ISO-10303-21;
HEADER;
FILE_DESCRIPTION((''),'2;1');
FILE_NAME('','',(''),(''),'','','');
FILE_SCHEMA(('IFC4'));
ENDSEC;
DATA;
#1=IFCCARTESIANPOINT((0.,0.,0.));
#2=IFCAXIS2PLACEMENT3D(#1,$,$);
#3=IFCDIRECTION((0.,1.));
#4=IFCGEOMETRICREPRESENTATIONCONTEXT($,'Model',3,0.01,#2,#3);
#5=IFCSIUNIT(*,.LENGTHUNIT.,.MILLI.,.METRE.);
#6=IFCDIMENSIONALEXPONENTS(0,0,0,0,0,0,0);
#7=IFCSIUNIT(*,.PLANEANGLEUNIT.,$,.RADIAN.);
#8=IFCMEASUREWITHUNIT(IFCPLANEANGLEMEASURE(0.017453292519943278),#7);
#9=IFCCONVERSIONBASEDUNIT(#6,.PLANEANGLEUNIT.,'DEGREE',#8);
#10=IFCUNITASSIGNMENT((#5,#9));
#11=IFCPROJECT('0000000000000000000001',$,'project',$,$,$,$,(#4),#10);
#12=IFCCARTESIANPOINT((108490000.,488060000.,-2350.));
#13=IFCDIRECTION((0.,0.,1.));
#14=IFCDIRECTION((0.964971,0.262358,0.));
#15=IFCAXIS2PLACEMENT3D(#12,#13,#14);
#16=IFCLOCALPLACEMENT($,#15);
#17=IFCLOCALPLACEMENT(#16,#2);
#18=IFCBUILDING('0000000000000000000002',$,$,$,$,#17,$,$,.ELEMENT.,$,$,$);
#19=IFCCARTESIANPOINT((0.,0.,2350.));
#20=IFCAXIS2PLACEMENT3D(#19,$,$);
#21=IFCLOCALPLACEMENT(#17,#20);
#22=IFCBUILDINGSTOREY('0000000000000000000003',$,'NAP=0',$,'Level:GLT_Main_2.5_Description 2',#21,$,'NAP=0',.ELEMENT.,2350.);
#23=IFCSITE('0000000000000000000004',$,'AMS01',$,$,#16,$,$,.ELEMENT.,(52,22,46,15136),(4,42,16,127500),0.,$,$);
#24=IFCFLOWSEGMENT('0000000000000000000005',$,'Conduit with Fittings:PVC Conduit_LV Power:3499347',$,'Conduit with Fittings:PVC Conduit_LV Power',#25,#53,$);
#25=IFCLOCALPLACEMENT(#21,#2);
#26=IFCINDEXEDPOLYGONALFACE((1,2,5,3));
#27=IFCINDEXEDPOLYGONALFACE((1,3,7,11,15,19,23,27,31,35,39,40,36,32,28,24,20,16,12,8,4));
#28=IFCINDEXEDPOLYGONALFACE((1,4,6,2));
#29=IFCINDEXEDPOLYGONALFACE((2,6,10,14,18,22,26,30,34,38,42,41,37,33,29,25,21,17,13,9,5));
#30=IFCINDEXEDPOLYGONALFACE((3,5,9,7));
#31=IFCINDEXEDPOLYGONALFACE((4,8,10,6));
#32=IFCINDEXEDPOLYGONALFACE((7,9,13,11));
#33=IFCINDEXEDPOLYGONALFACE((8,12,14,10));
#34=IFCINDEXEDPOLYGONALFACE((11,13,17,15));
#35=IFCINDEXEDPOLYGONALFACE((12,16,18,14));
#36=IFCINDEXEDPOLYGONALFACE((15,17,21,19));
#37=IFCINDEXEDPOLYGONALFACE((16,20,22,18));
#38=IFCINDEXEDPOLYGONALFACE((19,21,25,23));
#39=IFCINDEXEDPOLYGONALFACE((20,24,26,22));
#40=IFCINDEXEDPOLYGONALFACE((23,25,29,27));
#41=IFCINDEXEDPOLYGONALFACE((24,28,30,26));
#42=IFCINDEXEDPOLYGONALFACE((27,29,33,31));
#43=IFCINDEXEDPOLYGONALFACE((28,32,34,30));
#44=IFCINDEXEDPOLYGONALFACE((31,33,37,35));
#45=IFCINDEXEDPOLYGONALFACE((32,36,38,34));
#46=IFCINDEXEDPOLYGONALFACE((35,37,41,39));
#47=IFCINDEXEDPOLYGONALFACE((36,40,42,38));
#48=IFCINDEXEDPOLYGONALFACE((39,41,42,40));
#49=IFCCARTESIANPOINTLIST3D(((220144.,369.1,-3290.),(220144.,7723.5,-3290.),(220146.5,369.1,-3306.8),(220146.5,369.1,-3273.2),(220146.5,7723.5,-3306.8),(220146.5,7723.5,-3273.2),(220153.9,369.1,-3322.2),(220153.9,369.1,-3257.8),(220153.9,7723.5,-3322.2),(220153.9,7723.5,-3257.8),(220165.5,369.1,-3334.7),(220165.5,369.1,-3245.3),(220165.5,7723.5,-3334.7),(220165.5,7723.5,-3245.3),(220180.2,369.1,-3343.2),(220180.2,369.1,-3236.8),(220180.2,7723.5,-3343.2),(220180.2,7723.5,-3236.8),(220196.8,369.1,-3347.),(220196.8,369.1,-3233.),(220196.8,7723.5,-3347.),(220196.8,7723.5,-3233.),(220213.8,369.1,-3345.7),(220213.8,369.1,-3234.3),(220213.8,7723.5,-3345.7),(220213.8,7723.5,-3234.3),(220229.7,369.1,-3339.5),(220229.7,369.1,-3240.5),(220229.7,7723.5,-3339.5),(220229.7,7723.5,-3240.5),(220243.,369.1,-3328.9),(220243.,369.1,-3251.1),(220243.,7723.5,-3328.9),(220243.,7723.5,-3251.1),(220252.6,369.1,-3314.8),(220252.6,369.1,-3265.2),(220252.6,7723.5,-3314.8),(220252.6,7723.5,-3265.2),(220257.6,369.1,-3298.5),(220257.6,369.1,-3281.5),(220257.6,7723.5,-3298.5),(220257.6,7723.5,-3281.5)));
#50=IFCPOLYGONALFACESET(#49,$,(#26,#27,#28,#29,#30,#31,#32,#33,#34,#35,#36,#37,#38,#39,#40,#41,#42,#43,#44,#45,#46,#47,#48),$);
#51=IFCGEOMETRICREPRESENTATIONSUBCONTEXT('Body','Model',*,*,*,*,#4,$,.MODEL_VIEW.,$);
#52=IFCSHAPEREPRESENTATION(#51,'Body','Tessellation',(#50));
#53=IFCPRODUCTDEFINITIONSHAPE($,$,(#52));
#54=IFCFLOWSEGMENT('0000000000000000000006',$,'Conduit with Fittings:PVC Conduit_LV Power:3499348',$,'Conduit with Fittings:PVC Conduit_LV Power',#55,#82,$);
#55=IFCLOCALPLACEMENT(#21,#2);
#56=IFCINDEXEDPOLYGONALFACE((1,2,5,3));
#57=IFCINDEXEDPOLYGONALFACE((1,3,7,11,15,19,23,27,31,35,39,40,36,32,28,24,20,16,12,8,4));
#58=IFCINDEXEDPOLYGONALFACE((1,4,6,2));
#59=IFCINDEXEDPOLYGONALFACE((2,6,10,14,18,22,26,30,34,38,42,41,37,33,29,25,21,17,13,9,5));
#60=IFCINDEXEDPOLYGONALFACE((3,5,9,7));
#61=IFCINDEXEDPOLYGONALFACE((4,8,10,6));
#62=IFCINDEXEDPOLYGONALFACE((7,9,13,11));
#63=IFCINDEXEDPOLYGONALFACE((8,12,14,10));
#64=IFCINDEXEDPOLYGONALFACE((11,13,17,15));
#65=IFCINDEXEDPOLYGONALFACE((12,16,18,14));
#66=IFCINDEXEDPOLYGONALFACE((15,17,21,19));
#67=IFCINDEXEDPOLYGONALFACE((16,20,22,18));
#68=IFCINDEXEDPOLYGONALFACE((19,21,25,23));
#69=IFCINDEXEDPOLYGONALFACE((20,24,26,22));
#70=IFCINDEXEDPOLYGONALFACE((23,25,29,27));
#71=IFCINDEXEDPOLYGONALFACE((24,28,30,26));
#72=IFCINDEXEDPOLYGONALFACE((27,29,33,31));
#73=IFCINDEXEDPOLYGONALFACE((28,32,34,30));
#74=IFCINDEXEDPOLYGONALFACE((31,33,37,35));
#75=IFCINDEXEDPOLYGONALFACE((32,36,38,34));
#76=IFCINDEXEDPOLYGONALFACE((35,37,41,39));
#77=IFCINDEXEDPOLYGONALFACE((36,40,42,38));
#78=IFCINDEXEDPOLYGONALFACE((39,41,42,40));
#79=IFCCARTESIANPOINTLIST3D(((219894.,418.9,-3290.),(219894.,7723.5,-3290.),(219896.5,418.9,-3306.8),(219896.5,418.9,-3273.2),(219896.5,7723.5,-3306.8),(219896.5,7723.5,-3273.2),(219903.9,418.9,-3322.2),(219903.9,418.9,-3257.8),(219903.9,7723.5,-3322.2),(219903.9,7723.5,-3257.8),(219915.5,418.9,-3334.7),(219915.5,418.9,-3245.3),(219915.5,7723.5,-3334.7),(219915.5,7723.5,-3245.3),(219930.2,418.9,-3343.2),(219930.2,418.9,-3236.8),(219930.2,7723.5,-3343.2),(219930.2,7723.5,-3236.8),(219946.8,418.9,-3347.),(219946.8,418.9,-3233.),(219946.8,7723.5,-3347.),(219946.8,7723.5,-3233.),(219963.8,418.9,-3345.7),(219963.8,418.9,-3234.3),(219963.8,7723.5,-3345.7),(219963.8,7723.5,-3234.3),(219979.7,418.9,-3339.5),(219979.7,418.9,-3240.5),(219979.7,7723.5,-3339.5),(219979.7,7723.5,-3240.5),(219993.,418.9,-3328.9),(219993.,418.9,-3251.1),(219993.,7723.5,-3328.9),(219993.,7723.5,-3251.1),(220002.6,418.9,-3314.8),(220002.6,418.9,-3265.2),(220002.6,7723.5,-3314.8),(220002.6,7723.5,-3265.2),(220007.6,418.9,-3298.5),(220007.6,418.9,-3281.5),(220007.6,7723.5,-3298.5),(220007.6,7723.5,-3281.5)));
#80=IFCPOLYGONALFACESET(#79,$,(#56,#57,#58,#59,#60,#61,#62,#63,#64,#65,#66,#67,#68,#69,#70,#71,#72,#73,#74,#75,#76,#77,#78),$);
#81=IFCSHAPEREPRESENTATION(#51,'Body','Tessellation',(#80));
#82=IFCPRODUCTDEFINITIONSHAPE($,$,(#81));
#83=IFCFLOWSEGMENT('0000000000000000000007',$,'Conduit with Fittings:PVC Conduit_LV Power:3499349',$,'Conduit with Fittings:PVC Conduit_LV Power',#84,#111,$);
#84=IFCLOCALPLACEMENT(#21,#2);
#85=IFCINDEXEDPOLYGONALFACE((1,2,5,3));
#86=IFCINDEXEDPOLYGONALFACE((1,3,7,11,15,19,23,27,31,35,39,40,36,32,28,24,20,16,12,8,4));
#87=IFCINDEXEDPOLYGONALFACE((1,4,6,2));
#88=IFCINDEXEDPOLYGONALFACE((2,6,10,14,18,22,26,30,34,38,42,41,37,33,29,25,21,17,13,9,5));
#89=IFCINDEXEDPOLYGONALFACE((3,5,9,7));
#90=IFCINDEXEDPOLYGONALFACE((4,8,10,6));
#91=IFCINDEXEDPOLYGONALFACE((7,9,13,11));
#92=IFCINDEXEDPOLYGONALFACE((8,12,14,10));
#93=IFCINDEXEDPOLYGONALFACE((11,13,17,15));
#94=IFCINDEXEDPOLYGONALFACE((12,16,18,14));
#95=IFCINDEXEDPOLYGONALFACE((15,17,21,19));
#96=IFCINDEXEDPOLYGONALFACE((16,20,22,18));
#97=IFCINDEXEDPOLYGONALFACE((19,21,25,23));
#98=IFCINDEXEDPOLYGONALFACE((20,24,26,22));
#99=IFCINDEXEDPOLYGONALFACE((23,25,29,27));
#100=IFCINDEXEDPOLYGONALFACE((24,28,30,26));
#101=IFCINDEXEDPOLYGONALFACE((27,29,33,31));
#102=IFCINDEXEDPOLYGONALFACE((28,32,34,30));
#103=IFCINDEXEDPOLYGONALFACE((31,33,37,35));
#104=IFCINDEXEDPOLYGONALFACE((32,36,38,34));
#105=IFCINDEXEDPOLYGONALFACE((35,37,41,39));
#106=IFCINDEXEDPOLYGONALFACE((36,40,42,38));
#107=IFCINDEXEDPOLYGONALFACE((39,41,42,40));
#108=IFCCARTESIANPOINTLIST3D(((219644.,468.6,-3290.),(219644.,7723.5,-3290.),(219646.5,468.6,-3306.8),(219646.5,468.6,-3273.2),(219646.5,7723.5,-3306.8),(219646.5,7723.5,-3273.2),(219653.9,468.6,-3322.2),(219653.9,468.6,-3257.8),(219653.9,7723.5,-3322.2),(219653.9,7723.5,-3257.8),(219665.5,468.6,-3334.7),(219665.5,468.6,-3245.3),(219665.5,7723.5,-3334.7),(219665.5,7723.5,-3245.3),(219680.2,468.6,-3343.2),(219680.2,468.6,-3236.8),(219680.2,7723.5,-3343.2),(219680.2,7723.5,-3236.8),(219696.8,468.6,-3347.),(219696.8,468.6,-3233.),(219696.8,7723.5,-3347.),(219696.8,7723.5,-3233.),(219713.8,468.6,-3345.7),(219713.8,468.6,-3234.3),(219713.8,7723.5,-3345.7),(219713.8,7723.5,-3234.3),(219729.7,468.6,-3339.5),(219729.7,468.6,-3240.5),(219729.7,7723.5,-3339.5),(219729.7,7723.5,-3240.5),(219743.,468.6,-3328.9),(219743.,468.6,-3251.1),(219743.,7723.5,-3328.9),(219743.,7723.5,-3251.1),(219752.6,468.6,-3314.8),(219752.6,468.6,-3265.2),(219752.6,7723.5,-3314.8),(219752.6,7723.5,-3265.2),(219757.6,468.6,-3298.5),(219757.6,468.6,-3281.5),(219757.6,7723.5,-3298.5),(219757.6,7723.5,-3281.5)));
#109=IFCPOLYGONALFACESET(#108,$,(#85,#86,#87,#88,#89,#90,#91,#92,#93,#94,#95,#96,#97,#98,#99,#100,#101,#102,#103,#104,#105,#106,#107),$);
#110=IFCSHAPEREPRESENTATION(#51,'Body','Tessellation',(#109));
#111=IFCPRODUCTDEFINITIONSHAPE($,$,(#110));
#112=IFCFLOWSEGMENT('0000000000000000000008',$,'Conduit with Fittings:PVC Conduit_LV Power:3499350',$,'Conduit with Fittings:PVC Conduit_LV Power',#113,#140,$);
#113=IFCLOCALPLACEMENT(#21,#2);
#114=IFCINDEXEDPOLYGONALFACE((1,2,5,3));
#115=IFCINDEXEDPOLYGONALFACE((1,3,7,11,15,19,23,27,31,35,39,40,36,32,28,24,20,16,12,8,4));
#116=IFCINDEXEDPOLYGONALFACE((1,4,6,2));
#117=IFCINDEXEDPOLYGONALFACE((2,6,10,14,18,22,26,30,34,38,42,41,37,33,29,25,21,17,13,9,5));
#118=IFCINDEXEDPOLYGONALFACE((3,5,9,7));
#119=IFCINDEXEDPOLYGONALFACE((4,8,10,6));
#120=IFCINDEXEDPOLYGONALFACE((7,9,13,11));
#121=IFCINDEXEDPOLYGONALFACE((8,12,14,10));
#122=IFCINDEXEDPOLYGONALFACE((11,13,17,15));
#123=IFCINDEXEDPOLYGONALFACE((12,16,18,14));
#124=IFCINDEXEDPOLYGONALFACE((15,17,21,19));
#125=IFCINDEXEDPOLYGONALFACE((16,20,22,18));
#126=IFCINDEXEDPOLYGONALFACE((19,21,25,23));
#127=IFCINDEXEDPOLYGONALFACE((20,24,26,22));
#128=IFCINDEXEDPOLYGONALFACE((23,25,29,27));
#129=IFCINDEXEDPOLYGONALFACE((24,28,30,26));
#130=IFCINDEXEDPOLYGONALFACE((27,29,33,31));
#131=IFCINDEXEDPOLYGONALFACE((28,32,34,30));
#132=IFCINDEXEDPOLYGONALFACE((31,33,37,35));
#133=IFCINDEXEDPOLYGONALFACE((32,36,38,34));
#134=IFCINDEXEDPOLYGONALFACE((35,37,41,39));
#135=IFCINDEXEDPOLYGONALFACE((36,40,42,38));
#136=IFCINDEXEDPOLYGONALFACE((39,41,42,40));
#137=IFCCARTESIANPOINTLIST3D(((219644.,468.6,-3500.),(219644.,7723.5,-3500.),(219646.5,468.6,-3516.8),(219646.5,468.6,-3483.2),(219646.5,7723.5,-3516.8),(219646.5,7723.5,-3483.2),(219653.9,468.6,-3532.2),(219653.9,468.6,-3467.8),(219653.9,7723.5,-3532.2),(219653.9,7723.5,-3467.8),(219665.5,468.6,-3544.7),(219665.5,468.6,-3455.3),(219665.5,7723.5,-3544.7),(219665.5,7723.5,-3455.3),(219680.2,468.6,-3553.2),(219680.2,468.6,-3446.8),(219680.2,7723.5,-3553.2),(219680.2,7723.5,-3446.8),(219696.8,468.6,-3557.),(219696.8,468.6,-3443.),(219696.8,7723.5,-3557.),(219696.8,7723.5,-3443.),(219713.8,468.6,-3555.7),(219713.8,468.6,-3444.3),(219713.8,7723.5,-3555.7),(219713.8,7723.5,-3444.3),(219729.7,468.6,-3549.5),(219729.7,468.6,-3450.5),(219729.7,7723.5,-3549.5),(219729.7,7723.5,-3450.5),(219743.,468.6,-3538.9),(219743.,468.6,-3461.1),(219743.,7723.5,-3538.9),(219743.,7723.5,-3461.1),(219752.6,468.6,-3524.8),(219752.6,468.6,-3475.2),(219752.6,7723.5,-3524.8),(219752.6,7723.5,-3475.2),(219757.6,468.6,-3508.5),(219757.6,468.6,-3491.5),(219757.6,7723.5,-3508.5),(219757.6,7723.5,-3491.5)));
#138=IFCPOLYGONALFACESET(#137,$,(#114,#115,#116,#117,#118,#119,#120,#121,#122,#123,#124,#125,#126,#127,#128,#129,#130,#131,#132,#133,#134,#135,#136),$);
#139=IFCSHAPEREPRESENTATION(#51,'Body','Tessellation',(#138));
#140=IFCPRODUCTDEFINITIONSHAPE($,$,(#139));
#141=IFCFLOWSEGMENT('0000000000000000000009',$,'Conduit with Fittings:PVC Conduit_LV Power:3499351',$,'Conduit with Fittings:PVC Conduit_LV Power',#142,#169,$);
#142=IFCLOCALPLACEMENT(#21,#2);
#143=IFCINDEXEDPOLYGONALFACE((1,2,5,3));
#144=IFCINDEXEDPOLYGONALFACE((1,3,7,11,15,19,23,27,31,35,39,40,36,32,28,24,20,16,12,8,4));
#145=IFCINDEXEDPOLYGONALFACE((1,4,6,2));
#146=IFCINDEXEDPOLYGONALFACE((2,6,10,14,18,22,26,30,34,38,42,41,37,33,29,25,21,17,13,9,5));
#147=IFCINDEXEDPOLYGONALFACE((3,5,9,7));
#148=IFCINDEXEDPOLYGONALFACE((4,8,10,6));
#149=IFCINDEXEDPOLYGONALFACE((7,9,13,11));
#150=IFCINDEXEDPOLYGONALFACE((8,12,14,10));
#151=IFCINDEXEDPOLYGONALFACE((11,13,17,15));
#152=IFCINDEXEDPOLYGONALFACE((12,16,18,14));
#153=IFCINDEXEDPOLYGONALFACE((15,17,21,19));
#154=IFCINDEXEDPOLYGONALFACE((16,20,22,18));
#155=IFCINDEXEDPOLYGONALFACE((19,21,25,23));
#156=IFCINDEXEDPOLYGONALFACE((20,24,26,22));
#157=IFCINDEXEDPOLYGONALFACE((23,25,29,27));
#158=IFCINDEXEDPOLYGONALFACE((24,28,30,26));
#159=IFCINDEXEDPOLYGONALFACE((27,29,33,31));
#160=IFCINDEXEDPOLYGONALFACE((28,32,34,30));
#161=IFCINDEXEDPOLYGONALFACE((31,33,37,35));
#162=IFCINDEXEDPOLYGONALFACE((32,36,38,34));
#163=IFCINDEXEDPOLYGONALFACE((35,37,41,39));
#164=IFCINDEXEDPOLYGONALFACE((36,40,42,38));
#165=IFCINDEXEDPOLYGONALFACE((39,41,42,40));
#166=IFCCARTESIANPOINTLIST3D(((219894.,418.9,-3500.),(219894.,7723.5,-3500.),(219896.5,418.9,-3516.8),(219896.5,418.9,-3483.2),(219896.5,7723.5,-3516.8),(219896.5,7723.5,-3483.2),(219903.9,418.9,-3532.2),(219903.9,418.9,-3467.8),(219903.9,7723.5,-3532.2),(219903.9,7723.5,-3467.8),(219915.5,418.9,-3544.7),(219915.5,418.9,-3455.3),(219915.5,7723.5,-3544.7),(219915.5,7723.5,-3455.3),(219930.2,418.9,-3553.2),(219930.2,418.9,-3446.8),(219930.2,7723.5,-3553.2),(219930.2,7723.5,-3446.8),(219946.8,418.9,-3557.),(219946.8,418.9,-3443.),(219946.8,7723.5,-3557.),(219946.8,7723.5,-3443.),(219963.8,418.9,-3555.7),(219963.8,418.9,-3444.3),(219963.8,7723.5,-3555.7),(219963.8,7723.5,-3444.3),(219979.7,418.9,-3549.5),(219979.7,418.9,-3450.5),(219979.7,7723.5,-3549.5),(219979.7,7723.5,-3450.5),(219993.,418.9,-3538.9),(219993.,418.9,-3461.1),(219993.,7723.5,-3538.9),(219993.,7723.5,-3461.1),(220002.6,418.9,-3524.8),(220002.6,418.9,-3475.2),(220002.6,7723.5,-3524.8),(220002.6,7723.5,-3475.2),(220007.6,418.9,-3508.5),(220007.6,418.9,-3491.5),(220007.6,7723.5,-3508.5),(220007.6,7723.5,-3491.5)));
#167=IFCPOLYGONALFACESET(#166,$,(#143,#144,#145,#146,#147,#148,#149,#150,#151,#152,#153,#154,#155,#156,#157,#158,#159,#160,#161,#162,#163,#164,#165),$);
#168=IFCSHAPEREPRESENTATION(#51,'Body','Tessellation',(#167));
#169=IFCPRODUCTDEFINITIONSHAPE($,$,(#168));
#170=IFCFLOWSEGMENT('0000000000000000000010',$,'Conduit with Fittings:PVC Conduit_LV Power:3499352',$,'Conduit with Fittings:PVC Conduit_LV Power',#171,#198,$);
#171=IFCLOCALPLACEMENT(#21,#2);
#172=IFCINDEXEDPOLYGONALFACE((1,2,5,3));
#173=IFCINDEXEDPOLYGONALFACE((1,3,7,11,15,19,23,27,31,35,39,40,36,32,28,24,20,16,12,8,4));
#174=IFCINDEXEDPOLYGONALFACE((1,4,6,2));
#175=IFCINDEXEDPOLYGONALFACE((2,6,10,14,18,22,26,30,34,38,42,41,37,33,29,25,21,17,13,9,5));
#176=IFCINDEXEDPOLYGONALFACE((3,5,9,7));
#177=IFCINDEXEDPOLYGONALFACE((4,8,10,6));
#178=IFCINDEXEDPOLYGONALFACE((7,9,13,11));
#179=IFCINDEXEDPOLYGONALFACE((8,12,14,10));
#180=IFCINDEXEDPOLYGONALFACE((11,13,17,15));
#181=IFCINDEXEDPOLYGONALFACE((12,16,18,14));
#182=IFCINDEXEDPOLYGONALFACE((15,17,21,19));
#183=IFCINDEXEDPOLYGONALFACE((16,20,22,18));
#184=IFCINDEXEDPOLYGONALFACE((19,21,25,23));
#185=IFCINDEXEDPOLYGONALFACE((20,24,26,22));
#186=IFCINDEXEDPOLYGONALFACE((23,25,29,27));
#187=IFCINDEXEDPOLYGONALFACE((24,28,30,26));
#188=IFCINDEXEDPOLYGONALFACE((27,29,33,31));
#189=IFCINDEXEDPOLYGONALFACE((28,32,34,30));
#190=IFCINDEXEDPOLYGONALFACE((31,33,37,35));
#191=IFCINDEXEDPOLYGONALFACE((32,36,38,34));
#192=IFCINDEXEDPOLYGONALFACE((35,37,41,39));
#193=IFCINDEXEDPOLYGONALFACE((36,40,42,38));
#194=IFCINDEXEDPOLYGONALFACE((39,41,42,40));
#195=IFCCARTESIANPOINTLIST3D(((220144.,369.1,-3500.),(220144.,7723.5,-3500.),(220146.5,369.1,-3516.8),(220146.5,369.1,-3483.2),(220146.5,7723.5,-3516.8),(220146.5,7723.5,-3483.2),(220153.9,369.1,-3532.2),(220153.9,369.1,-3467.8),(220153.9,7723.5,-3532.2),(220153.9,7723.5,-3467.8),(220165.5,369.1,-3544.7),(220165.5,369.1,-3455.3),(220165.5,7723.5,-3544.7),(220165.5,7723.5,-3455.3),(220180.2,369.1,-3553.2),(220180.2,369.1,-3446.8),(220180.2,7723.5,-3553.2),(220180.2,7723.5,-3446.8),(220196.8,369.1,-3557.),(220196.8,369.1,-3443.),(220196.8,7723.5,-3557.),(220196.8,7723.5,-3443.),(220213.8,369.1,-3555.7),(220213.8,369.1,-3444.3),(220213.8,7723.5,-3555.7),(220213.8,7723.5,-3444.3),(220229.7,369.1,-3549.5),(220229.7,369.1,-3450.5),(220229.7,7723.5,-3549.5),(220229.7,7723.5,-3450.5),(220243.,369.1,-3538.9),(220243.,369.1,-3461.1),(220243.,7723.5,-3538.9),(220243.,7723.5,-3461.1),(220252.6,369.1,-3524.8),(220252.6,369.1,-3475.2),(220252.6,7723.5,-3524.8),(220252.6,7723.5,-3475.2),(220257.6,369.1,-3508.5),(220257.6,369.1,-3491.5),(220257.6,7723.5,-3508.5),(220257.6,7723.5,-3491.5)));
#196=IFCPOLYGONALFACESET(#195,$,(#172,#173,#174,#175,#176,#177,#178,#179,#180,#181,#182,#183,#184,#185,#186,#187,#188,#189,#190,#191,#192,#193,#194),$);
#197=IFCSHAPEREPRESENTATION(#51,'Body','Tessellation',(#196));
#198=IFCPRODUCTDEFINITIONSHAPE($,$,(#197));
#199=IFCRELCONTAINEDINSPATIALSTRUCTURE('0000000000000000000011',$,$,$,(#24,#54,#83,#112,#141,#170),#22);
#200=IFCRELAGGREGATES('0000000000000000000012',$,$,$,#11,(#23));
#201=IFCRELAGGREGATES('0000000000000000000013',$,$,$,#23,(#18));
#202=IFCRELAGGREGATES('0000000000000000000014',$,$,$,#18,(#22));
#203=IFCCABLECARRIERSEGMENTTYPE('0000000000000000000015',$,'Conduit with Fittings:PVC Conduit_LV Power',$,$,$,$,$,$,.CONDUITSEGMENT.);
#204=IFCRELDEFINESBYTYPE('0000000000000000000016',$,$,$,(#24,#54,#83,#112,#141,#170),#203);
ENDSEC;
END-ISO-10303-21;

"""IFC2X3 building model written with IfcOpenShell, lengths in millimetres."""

from ifc_helpers import new_model, entity, si_unit, converted_unit, direction, frame, frame_2d, origin, place, context, subcontext, project, spatial, circle, extrude, type_object, element, save


model = new_model("IFC2X3")

# Units and contexts
model_context = context("Model", 3, precision=0.01, world=origin(), true_north=direction((0.0, 1.0)))
body_context = subcontext(model_context, "Body", "Model", "MODEL_VIEW")
ifc_project = project(units=[si_unit("LENGTHUNIT", "METRE", prefix="MILLI"), converted_unit("PLANEANGLEUNIT", "DEGREE", entity("IfcPlaneAngleMeasure", 0.017453292519943278), si_unit("PLANEANGLEUNIT", "RADIAN"), dimensions=[0, 0, 0, 0, 0, 0, 0])], contexts=[model_context])

# Site, building, storey
site_placement = place(None, frame((108490000.0, 488060000.0, -2350.0), z_axis=(0.0, 0.0, 1.0), x_axis=(0.964971, 0.262358, 0.0)))
site = spatial("IfcSite", under=ifc_project, at=site_placement, Name="AMS01", CompositionType="ELEMENT", RefLatitude=(52, 22, 46, 15136), RefLongitude=(4, 42, 16, 127500), RefElevation=0.0)
building_placement = place(site_placement, origin())
building = spatial("IfcBuilding", under=site, at=building_placement, CompositionType="ELEMENT")
storey_placement = place(building_placement, frame((0.0, 0.0, 2350.0)))
storey = spatial("IfcBuildingStorey", under=building, at=storey_placement, Name="NAP=0", ObjectType="Level:GLT_Main_2.5_Description 2", LongName="NAP=0", CompositionType="ELEMENT", Elevation=2350.0)

# Flow segments
cable_carrier_segment_type = type_object("IfcCableCarrierSegmentType", Name="Conduit with Fittings:PVC Conduit_LV Power", PredefinedType="CONDUITSEGMENT")
flow_segment_1_placement = place(storey_placement, origin())
element("IfcFlowSegment", 1, at=flow_segment_1_placement, inside=storey, type_object=cable_carrier_segment_type, Name="Conduit with Fittings:PVC Conduit_LV Power:3499347", ObjectType="Conduit with Fittings:PVC Conduit_LV Power", context=body_context, shape_type="SweptSolid", body=[
    extrude(circle(Radius=57.2, at=frame_2d((0.0, 0.0), x_axis=(1.0, 0.0))), frame((220201.1, 369.1, -3290.0), z_axis=(0.0, 1.0, 0.0), x_axis=(-1.0, 0.0, 0.0)), (0.0, 0.0, 1.0), 7354.3),
])
flow_segment_2_placement = place(storey_placement, origin())
element("IfcFlowSegment", 2, at=flow_segment_2_placement, inside=storey, type_object=cable_carrier_segment_type, Name="Conduit with Fittings:PVC Conduit_LV Power:3499348", ObjectType="Conduit with Fittings:PVC Conduit_LV Power", context=body_context, shape_type="SweptSolid", body=[
    extrude(circle(Radius=57.2, at=frame_2d((0.0, 0.0), x_axis=(1.0, 0.0))), frame((219951.1, 418.9, -3290.0), z_axis=(0.0, 1.0, 0.0), x_axis=(-1.0, 0.0, 0.0)), (0.0, 0.0, 1.0), 7304.6),
])
flow_segment_3_placement = place(storey_placement, origin())
element("IfcFlowSegment", 3, at=flow_segment_3_placement, inside=storey, type_object=cable_carrier_segment_type, Name="Conduit with Fittings:PVC Conduit_LV Power:3499349", ObjectType="Conduit with Fittings:PVC Conduit_LV Power", context=body_context, shape_type="SweptSolid", body=[
    extrude(circle(Radius=57.2, at=frame_2d((0.0, 0.0), x_axis=(1.0, 0.0))), frame((219701.1, 468.6, -3290.0), z_axis=(0.0, 1.0, 0.0), x_axis=(-1.0, 0.0, 0.0)), (0.0, 0.0, 1.0), 7254.9),
])
flow_segment_4_placement = place(storey_placement, origin())
element("IfcFlowSegment", 4, at=flow_segment_4_placement, inside=storey, type_object=cable_carrier_segment_type, Name="Conduit with Fittings:PVC Conduit_LV Power:3499350", ObjectType="Conduit with Fittings:PVC Conduit_LV Power", context=body_context, shape_type="SweptSolid", body=[
    extrude(circle(Radius=57.2, at=frame_2d((0.0, 0.0), x_axis=(1.0, 0.0))), frame((219701.1, 468.6, -3500.0), z_axis=(0.0, 1.0, 0.0), x_axis=(-1.0, 0.0, 0.0)), (0.0, 0.0, 1.0), 7254.9),
])
flow_segment_5_placement = place(storey_placement, origin())
element("IfcFlowSegment", 5, at=flow_segment_5_placement, inside=storey, type_object=cable_carrier_segment_type, Name="Conduit with Fittings:PVC Conduit_LV Power:3499351", ObjectType="Conduit with Fittings:PVC Conduit_LV Power", context=body_context, shape_type="SweptSolid", body=[
    extrude(circle(Radius=57.2, at=frame_2d((0.0, 0.0), x_axis=(1.0, 0.0))), frame((219951.1, 418.9, -3500.0), z_axis=(0.0, 1.0, 0.0), x_axis=(-1.0, 0.0, 0.0)), (0.0, 0.0, 1.0), 7304.6),
])
flow_segment_6_placement = place(storey_placement, origin())
element("IfcFlowSegment", 6, at=flow_segment_6_placement, inside=storey, type_object=cable_carrier_segment_type, Name="Conduit with Fittings:PVC Conduit_LV Power:3499352", ObjectType="Conduit with Fittings:PVC Conduit_LV Power", context=body_context, shape_type="SweptSolid", body=[
    extrude(circle(Radius=57.2, at=frame_2d((0.0, 0.0), x_axis=(1.0, 0.0))), frame((220201.1, 369.1, -3500.0), z_axis=(0.0, 1.0, 0.0), x_axis=(-1.0, 0.0, 0.0)), (0.0, 0.0, 1.0), 7354.3),
])

save(model, "model.ifc")
